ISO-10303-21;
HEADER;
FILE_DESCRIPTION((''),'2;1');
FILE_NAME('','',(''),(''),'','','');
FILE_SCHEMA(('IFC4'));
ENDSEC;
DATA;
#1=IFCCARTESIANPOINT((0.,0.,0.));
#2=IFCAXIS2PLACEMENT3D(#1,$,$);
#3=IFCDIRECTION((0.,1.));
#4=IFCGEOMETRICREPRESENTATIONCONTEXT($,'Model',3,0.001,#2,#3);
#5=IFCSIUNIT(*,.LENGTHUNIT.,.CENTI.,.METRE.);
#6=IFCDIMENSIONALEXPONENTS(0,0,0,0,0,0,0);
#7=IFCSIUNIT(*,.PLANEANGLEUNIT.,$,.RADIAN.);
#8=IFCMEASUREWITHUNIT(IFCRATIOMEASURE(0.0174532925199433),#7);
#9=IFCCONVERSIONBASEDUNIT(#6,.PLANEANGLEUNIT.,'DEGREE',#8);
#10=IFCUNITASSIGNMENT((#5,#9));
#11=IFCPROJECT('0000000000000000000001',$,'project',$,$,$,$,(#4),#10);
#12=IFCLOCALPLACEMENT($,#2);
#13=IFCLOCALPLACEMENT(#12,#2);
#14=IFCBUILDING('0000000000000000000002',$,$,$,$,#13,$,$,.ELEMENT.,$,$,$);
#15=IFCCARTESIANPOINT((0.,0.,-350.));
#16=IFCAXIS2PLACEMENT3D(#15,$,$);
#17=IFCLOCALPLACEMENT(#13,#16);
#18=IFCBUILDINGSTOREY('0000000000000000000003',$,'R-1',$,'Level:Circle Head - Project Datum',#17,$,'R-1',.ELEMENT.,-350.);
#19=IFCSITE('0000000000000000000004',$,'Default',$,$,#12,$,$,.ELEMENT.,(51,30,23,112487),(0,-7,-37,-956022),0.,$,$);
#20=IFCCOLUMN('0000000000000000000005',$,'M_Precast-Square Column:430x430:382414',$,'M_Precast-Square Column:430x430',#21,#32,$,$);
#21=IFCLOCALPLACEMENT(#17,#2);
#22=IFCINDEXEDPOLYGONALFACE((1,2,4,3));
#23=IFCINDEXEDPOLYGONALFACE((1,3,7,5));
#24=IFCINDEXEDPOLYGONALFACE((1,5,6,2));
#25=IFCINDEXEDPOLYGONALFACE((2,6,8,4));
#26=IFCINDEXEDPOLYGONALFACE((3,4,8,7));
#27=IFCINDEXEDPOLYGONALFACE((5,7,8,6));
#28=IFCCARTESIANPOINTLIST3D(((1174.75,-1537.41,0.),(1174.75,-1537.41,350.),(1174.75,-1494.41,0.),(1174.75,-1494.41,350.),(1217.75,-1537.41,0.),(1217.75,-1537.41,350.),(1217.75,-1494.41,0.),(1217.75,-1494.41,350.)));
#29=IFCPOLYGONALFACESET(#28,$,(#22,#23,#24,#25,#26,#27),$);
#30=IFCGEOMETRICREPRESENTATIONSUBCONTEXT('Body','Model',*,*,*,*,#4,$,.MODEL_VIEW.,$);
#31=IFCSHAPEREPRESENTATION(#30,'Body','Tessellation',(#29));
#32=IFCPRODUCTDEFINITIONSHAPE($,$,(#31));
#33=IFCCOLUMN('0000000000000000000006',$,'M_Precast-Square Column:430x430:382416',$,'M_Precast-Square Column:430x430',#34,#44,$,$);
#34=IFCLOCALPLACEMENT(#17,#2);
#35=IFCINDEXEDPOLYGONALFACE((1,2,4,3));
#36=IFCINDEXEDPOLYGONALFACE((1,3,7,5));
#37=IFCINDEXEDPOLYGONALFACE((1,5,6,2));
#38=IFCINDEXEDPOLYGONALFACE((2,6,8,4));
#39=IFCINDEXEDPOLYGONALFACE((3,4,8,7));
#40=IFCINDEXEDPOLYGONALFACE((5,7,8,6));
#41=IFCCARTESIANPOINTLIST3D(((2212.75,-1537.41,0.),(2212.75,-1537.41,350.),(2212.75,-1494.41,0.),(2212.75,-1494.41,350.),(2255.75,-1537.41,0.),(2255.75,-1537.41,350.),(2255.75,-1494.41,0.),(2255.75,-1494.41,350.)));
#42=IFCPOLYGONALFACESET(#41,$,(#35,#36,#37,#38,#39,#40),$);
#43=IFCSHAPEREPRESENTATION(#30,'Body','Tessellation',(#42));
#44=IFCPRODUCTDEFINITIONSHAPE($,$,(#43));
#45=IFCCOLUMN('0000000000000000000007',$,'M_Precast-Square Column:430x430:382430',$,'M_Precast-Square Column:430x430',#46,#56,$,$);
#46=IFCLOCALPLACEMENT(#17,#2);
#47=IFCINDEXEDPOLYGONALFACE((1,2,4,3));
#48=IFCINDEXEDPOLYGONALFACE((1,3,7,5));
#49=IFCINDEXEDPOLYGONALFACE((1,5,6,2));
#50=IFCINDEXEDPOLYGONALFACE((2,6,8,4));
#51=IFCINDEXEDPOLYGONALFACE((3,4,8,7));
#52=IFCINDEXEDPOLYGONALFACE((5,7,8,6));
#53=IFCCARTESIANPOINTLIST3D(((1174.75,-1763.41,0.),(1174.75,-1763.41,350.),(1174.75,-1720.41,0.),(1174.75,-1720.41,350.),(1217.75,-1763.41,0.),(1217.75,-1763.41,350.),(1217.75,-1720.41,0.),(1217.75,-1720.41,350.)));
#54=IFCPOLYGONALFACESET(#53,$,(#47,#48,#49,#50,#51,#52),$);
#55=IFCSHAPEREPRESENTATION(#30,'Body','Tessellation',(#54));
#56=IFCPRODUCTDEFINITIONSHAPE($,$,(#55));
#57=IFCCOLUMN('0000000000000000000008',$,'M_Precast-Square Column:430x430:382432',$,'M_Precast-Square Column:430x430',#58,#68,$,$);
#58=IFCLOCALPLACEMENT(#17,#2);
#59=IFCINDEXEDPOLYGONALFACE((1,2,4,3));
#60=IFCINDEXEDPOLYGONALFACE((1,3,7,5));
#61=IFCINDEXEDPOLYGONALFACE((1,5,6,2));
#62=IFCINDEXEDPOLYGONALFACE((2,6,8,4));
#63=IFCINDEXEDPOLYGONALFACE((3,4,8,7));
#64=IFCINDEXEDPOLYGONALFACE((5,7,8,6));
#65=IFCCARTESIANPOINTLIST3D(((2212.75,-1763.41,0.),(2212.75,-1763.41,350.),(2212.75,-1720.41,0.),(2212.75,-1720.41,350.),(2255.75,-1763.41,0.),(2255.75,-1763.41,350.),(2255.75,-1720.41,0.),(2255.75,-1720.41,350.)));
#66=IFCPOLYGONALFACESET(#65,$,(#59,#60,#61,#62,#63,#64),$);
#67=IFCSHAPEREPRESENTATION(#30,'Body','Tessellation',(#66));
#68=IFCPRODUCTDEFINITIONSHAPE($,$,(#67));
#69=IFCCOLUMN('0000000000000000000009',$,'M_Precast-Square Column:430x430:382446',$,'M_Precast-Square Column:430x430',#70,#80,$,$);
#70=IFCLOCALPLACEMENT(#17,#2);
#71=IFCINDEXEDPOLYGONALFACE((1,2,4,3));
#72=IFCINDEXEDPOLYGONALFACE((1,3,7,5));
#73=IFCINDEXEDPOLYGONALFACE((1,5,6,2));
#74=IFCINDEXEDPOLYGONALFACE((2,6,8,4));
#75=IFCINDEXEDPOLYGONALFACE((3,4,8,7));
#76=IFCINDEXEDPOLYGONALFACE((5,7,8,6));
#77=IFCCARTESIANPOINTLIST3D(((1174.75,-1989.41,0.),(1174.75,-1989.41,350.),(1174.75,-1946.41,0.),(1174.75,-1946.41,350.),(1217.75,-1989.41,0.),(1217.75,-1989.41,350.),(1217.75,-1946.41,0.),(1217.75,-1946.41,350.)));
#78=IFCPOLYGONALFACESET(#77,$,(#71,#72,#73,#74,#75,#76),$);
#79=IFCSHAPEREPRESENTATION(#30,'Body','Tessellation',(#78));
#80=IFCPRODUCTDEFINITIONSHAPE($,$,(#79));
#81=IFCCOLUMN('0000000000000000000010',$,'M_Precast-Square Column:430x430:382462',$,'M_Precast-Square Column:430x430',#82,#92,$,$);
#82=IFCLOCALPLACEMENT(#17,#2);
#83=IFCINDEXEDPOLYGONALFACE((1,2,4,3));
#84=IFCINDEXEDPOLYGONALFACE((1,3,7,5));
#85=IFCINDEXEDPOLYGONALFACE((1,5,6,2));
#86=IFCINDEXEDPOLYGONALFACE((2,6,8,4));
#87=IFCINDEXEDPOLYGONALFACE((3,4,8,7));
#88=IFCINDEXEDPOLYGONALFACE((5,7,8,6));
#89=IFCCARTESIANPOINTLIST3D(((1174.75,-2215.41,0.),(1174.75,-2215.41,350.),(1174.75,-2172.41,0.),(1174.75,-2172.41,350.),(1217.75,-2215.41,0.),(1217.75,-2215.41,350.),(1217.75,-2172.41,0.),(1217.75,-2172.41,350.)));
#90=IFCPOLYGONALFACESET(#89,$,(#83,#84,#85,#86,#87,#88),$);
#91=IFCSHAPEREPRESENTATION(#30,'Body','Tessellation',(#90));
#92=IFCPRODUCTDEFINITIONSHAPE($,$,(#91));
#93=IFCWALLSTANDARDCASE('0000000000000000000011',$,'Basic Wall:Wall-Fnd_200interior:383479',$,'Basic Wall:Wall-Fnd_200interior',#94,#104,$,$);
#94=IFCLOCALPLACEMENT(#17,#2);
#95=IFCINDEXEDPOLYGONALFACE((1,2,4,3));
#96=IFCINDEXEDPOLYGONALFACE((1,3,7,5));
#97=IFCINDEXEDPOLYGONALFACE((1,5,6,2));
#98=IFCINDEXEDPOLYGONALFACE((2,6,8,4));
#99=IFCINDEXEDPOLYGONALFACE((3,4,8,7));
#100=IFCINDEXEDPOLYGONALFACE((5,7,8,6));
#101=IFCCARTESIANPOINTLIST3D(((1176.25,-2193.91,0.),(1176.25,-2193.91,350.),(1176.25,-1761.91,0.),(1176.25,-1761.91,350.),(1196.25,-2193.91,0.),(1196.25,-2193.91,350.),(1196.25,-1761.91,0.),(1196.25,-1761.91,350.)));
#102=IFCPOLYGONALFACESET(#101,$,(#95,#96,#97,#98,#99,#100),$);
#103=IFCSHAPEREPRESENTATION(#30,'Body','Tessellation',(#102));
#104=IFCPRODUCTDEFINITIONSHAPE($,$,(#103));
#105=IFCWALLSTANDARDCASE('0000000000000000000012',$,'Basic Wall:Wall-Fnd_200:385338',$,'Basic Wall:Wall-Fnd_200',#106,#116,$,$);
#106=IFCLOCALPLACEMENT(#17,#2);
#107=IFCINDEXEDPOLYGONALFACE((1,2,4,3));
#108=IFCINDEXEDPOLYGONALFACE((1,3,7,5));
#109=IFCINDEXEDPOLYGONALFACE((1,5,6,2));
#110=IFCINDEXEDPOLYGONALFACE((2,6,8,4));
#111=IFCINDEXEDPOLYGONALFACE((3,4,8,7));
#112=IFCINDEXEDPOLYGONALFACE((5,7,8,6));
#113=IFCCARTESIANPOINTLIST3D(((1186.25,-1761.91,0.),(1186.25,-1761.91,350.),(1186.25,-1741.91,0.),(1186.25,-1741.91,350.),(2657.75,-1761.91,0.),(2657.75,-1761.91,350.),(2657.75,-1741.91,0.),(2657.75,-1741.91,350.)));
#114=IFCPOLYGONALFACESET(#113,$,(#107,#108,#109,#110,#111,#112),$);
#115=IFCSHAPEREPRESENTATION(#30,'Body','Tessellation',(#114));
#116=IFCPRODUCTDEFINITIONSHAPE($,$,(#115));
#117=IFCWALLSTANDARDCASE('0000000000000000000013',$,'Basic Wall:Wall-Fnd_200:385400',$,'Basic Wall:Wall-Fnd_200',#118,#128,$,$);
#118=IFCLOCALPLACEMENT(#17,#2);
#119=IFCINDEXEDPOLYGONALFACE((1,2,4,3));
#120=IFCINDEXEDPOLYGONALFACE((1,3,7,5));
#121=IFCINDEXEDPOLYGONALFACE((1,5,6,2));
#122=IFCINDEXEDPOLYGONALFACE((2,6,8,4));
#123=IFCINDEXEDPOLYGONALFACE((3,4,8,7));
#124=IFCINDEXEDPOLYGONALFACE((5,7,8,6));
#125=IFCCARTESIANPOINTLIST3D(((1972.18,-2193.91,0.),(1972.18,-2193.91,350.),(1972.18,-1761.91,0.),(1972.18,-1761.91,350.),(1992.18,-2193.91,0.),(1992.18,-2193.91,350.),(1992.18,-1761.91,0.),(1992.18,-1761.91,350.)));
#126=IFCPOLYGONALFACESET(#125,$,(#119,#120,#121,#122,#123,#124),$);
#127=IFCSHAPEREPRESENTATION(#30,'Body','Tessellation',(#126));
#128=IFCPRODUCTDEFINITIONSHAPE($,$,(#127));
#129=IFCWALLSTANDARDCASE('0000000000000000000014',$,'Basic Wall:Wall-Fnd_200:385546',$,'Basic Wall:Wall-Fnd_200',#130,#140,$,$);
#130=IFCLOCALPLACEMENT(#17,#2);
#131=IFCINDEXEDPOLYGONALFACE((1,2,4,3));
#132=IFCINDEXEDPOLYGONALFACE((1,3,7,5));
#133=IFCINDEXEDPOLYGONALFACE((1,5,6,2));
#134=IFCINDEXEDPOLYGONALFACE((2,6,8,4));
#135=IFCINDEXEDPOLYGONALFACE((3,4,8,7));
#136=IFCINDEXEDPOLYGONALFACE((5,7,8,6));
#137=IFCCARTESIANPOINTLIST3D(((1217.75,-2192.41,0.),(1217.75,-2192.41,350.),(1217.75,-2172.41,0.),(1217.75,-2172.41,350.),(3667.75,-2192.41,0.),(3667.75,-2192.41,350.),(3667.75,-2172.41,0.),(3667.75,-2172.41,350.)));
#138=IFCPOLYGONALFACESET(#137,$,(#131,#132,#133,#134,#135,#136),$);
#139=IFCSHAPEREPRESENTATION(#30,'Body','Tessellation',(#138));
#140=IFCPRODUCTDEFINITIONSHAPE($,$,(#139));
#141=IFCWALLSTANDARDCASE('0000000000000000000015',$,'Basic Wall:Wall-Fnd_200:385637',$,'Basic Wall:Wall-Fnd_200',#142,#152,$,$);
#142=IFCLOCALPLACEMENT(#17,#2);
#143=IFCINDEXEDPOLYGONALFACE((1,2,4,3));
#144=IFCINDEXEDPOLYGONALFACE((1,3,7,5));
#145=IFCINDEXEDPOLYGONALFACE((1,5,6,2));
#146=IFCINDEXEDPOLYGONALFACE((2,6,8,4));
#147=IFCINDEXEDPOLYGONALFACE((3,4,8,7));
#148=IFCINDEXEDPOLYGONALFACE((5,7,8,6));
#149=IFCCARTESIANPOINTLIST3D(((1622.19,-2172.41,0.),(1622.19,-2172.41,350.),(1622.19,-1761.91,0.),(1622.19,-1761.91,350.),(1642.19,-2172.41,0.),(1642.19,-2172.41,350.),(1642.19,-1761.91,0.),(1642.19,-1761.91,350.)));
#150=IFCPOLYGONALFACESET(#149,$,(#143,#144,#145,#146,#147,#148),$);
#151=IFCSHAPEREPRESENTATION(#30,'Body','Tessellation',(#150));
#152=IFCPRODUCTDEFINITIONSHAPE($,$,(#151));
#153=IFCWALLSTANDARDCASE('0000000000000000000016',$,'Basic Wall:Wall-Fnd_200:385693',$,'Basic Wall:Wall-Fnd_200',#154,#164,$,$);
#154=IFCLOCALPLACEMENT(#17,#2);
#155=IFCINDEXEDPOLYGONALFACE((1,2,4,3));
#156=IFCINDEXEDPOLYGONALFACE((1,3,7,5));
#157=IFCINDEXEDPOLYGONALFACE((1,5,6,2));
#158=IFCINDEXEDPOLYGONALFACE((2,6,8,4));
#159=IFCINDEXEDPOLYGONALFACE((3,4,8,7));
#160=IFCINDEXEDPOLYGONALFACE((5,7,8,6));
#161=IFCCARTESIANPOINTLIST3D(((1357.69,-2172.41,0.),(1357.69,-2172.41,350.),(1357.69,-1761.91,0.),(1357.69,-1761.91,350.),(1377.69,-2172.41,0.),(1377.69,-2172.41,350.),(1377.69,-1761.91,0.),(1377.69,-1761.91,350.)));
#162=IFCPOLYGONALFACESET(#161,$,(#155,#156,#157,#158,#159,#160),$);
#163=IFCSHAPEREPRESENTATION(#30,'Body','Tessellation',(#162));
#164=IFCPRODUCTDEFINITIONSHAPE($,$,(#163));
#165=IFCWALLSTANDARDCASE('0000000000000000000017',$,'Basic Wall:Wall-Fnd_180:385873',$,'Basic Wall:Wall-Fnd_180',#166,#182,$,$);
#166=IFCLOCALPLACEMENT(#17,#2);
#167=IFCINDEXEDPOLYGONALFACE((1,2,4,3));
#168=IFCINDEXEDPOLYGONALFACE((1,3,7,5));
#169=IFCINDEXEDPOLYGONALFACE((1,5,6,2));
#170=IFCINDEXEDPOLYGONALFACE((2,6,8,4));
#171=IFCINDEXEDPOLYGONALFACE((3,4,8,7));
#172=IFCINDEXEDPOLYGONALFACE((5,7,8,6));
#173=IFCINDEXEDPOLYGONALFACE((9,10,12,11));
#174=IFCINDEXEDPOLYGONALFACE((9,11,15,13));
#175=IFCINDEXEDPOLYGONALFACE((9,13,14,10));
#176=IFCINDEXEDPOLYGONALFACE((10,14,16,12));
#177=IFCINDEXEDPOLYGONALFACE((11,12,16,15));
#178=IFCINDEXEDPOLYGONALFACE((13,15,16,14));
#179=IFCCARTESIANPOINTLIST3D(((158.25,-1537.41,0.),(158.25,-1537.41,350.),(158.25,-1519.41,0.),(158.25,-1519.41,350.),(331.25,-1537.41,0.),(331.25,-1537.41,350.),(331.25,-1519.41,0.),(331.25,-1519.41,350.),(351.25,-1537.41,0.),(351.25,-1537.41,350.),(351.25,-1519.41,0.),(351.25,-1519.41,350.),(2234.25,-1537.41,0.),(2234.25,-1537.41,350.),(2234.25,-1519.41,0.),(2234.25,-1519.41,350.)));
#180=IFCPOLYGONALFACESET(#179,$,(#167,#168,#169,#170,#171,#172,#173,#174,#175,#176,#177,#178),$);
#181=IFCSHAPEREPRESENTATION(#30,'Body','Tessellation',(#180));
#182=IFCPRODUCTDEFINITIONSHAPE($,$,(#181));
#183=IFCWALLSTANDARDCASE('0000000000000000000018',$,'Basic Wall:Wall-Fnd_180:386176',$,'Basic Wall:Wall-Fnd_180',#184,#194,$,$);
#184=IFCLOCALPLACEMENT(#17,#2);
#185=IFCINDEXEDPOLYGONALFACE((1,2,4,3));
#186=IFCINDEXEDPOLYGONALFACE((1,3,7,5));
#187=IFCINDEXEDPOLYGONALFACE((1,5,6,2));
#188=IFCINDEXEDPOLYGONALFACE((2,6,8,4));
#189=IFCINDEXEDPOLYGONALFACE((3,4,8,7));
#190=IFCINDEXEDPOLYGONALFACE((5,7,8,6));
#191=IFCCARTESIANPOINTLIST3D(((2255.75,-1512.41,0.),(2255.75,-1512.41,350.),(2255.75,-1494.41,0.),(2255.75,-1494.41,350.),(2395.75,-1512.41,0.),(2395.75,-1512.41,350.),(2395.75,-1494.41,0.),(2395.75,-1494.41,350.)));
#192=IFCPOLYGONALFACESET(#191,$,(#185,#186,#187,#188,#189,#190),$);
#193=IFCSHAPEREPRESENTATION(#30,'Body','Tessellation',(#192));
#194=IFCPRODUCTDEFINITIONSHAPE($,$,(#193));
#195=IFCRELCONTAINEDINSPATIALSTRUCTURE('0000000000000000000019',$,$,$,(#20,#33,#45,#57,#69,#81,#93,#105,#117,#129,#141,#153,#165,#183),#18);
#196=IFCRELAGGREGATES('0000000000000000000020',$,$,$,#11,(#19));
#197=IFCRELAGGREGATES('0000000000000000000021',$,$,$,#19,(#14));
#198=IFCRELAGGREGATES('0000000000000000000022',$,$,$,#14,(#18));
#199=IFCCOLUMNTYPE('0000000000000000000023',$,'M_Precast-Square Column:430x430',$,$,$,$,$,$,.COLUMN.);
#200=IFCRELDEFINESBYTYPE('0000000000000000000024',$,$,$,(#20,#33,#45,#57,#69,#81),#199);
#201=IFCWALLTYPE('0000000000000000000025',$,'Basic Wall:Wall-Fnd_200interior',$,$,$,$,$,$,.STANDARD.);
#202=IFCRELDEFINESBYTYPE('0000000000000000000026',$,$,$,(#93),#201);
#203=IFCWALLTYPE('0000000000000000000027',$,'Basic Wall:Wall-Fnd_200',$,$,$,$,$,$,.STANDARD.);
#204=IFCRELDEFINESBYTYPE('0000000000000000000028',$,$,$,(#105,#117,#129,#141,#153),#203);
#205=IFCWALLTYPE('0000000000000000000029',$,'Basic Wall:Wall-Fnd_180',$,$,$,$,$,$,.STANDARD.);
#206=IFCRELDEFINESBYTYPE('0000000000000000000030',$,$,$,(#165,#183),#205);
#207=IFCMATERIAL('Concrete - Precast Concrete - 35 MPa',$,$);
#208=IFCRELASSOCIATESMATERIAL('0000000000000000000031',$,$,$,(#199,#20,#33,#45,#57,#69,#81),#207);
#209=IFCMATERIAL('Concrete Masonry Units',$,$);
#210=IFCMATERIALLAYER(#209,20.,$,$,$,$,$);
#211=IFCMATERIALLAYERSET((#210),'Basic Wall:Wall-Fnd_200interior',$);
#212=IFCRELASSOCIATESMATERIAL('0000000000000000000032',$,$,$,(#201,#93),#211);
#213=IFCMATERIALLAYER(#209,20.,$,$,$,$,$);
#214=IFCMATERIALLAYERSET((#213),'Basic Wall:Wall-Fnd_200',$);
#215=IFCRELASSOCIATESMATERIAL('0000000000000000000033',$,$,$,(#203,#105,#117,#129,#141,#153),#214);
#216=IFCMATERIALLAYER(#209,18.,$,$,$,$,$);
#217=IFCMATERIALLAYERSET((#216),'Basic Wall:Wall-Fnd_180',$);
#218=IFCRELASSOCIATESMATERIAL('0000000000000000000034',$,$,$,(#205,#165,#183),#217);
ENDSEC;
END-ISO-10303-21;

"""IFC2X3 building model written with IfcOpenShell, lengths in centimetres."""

from ifc_helpers import new_model, entity, si_unit, converted_unit, direction, frame, frame_2d, origin, origin_2d_with_axis, place, context, subcontext, project, spatial, rectangle, extrude, source, transform, mapped, material, layer, layer_set, layer_usage, type_object, type_shapes, element, save


model = new_model("IFC2X3")

# Units and contexts
model_context = context("Model", 3, precision=0.001, world=origin(), true_north=direction((0.0, 1.0)))
body_context = subcontext(model_context, "Body", "Model", "MODEL_VIEW")
ifc_project = project(units=[si_unit("LENGTHUNIT", "METRE", prefix="CENTI"), converted_unit("PLANEANGLEUNIT", "DEGREE", entity("IfcRatioMeasure", 0.0174532925199433), si_unit("PLANEANGLEUNIT", "RADIAN"), dimensions=[0, 0, 0, 0, 0, 0, 0])], contexts=[model_context])

# Site, building, storey
site_placement = place(None, origin())
site = spatial("IfcSite", under=ifc_project, at=site_placement, Name="Default", CompositionType="ELEMENT", RefLatitude=(51, 30, 23, 112487), RefLongitude=(0, -7, -37, -956022), RefElevation=0.0)
building_placement = place(site_placement, origin())
building = spatial("IfcBuilding", under=site, at=building_placement, CompositionType="ELEMENT")
storey_placement = place(building_placement, frame((0.0, 0.0, -350.0)))
storey = spatial("IfcBuildingStorey", under=building, at=storey_placement, Name="R-1", ObjectType="Level:Circle Head - Project Datum", LongName="R-1", CompositionType="ELEMENT", Elevation=-350.0)

# Columns
ifc_material_1 = material(Name="Concrete - Precast Concrete - 35 MPa")
column_type_1 = type_object("IfcColumnType", Name="M_Precast-Square Column:430x430", PredefinedType="COLUMN", material=ifc_material_1)
shared_shape_1 = source(origin(), body_context, "Body", "SweptSolid", [
    extrude(rectangle(XDim=43.0, YDim=43.0, at=origin_2d_with_axis()), frame((0.0, 0.0, -350.0), z_axis=(0.0, 0.0, 1.0), x_axis=(0.0, -1.0, 0.0)), (0.0, 0.0, 1.0), 350.0),
])
type_shapes(column_type_1, [shared_shape_1])
for number, where, z_axis, x_axis, name in (
    (1, (1196.25, -1515.91, 350.0), (0.0, 0.0, 1.0), (-1.0, 0.0, 0.0), "M_Precast-Square Column:430x430:382414"),
    (2, (2234.25, -1515.91, 350.0), (0.0, 0.0, 1.0), (-1.0, 0.0, 0.0), "M_Precast-Square Column:430x430:382416"),
    (3, (1196.25, -1741.91, 350.0), (0.0, 0.0, 1.0), (-1.0, 0.0, 0.0), "M_Precast-Square Column:430x430:382430"),
    (4, (2234.25, -1741.91, 350.0), (0.0, 0.0, 1.0), (-1.0, 0.0, 0.0), "M_Precast-Square Column:430x430:382432"),
    (5, (1196.25, -1967.91, 350.0), (0.0, 0.0, 1.0), (-1.0, 0.0, 0.0), "M_Precast-Square Column:430x430:382446"),
    (6, (1196.25, -2193.91, 350.0), (0.0, 0.0, 1.0), (-1.0, 0.0, 0.0), "M_Precast-Square Column:430x430:382462"),
):
    element("IfcColumn", number, at=place(storey_placement, frame(where, z_axis=z_axis, x_axis=x_axis)), inside=storey, type_object=column_type_1, material=ifc_material_1, Name=name, ObjectType="M_Precast-Square Column:430x430", context=body_context, shape_type="MappedRepresentation", body=[
        mapped(shared_shape_1, transform((0.0, 0.0, 0.0), scale=1.0)),
    ])

# Walls
ifc_material_2 = material(Name="Concrete Masonry Units")
ifc_layer_1 = layer(ifc_material_2, 20.0)
ifc_layer_set_1 = layer_set([ifc_layer_1], Name="Basic Wall:Wall-Fnd_200interior")
ifc_layer_usage_1 = layer_usage(ifc_layer_set_1, "AXIS2", "POSITIVE", -10.0)
wall_type_1 = type_object("IfcWallType", Name="Basic Wall:Wall-Fnd_200interior", PredefinedType="STANDARD", material=ifc_layer_set_1)
wall_1_placement = place(storey_placement, frame((1186.25, -2193.91, 0.0), z_axis=(0.0, 0.0, 1.0), x_axis=(0.0, 1.0, 0.0)))
element("IfcWallStandardCase", 7, at=wall_1_placement, inside=storey, type_object=wall_type_1, material=ifc_layer_usage_1, Name="Basic Wall:Wall-Fnd_200interior:383479", ObjectType="Basic Wall:Wall-Fnd_200interior", context=body_context, shape_type="SweptSolid", body=[
    extrude(rectangle(XDim=432.0, YDim=20.0, at=frame_2d((216.0, 0.0), x_axis=(-1.0, 0.0))), origin(), (0.0, 0.0, 1.0), 350.0),
])
ifc_layer_2 = layer(ifc_material_2, 20.0)
ifc_layer_set_2 = layer_set([ifc_layer_2], Name="Basic Wall:Wall-Fnd_200")
ifc_layer_usage_2 = layer_usage(ifc_layer_set_2, "AXIS2", "NEGATIVE", 10.0)
wall_type_2 = type_object("IfcWallType", Name="Basic Wall:Wall-Fnd_200", PredefinedType="STANDARD", material=ifc_layer_set_2)
wall_2_placement = place(storey_placement, frame((1186.25, -1751.91, 0.0)))
element("IfcWallStandardCase", 8, at=wall_2_placement, inside=storey, type_object=wall_type_2, material=ifc_layer_usage_2, Name="Basic Wall:Wall-Fnd_200:385338", ObjectType="Basic Wall:Wall-Fnd_200", context=body_context, shape_type="SweptSolid", body=[
    extrude(rectangle(XDim=1471.5, YDim=20.0, at=frame_2d((735.75, 0.0), x_axis=(-1.0, 0.0))), origin(), (0.0, 0.0, 1.0), 350.0),
])
ifc_layer_usage_3 = layer_usage(ifc_layer_set_2, "AXIS2", "NEGATIVE", 10.0)
wall_3_placement = place(storey_placement, frame((1982.18, -2193.91, 0.0), z_axis=(0.0, 0.0, 1.0), x_axis=(0.0, 1.0, 0.0)))
element("IfcWallStandardCase", 9, at=wall_3_placement, inside=storey, type_object=wall_type_2, material=ifc_layer_usage_3, Name="Basic Wall:Wall-Fnd_200:385400", ObjectType="Basic Wall:Wall-Fnd_200", context=body_context, shape_type="SweptSolid", body=[
    extrude(rectangle(XDim=432.0, YDim=20.0, at=frame_2d((216.0, 0.0), x_axis=(-1.0, 0.0))), origin(), (0.0, 0.0, 1.0), 350.0),
])
ifc_layer_usage_4 = layer_usage(ifc_layer_set_2, "AXIS2", "NEGATIVE", 10.0)
wall_4_placement = place(storey_placement, frame((1217.75, -2182.41, 0.0)))
element("IfcWallStandardCase", 10, at=wall_4_placement, inside=storey, type_object=wall_type_2, material=ifc_layer_usage_4, Name="Basic Wall:Wall-Fnd_200:385546", ObjectType="Basic Wall:Wall-Fnd_200", context=body_context, shape_type="SweptSolid", body=[
    extrude(rectangle(XDim=2450.0, YDim=20.0, at=frame_2d((1225.0, 0.0), x_axis=(-1.0, 0.0))), origin(), (0.0, 0.0, 1.0), 350.0),
])
ifc_layer_usage_5 = layer_usage(ifc_layer_set_2, "AXIS2", "POSITIVE", -10.0)
wall_5_placement = place(storey_placement, frame((1632.19, -1761.91, 0.0), z_axis=(0.0, 0.0, 1.0), x_axis=(0.0, -1.0, 0.0)))
element("IfcWallStandardCase", 11, at=wall_5_placement, inside=storey, type_object=wall_type_2, material=ifc_layer_usage_5, Name="Basic Wall:Wall-Fnd_200:385637", ObjectType="Basic Wall:Wall-Fnd_200", context=body_context, shape_type="SweptSolid", body=[
    extrude(rectangle(XDim=410.5, YDim=20.0, at=frame_2d((205.25, 0.0), x_axis=(-1.0, 0.0))), origin(), (0.0, 0.0, 1.0), 350.0),
])
ifc_layer_usage_6 = layer_usage(ifc_layer_set_2, "AXIS2", "POSITIVE", -10.0)
wall_6_placement = place(storey_placement, frame((1367.69, -1761.91, 0.0), z_axis=(0.0, 0.0, 1.0), x_axis=(0.0, -1.0, 0.0)))
element("IfcWallStandardCase", 12, at=wall_6_placement, inside=storey, type_object=wall_type_2, material=ifc_layer_usage_6, Name="Basic Wall:Wall-Fnd_200:385693", ObjectType="Basic Wall:Wall-Fnd_200", context=body_context, shape_type="SweptSolid", body=[
    extrude(rectangle(XDim=410.5, YDim=20.0, at=frame_2d((205.25, 0.0), x_axis=(-1.0, 0.0))), origin(), (0.0, 0.0, 1.0), 350.0),
])

# Wall, opening
ifc_layer_3 = layer(ifc_material_2, 18.0)
ifc_layer_set_3 = layer_set([ifc_layer_3], Name="Basic Wall:Wall-Fnd_180")
ifc_layer_usage_7 = layer_usage(ifc_layer_set_3, "AXIS2", "NEGATIVE", 9.0)
wall_type_3 = type_object("IfcWallType", Name="Basic Wall:Wall-Fnd_180", PredefinedType="STANDARD", material=ifc_layer_set_3)
wall_7_placement = place(storey_placement, frame((2234.25, -1528.41, 0.0), z_axis=(0.0, 0.0, 1.0), x_axis=(-1.0, 0.0, 0.0)))
wall_7 = element("IfcWallStandardCase", 13, at=wall_7_placement, inside=storey, type_object=wall_type_3, material=ifc_layer_usage_7, Name="Basic Wall:Wall-Fnd_180:385873", ObjectType="Basic Wall:Wall-Fnd_180", context=body_context, shape_type="SweptSolid", body=[
    extrude(rectangle(XDim=2076.0, YDim=18.0, at=frame_2d((1038.0, 0.0), x_axis=(-1.0, 0.0))), origin(), (0.0, 0.0, 1.0), 350.0),
])
opening_1_placement = place(storey_placement, frame((2234.25, -1528.41, 0.0), z_axis=(0.0, 0.0, 1.0), x_axis=(-1.0, 0.0, 0.0)))
element("IfcOpeningElement", 14, at=opening_1_placement, cuts=wall_7, ObjectType="Opening", context=body_context, shape_type="SweptSolid", body=[
    extrude(rectangle(XDim=350.0, YDim=18.0, at=frame_2d((0.0, 0.0), x_axis=(1.0, 0.0))), frame((1903.0, 0.0, 175.0), z_axis=(-1.0, 0.0, 0.0), x_axis=(0.0, 0.0, 1.0)), (0.0, 0.0, 1.0), 20.0),
])

# Wall
ifc_layer_usage_8 = layer_usage(ifc_layer_set_3, "AXIS2", "NEGATIVE", 9.0)
wall_8_placement = place(storey_placement, frame((2255.75, -1503.41, 0.0)))
element("IfcWallStandardCase", 15, at=wall_8_placement, inside=storey, type_object=wall_type_3, material=ifc_layer_usage_8, Name="Basic Wall:Wall-Fnd_180:386176", ObjectType="Basic Wall:Wall-Fnd_180", context=body_context, shape_type="SweptSolid", body=[
    extrude(rectangle(XDim=140.0, YDim=18.0, at=frame_2d((70.0, 0.0), x_axis=(-1.0, 0.0))), origin(), (0.0, 0.0, 1.0), 350.0),
])

save(model, "model.ifc")
